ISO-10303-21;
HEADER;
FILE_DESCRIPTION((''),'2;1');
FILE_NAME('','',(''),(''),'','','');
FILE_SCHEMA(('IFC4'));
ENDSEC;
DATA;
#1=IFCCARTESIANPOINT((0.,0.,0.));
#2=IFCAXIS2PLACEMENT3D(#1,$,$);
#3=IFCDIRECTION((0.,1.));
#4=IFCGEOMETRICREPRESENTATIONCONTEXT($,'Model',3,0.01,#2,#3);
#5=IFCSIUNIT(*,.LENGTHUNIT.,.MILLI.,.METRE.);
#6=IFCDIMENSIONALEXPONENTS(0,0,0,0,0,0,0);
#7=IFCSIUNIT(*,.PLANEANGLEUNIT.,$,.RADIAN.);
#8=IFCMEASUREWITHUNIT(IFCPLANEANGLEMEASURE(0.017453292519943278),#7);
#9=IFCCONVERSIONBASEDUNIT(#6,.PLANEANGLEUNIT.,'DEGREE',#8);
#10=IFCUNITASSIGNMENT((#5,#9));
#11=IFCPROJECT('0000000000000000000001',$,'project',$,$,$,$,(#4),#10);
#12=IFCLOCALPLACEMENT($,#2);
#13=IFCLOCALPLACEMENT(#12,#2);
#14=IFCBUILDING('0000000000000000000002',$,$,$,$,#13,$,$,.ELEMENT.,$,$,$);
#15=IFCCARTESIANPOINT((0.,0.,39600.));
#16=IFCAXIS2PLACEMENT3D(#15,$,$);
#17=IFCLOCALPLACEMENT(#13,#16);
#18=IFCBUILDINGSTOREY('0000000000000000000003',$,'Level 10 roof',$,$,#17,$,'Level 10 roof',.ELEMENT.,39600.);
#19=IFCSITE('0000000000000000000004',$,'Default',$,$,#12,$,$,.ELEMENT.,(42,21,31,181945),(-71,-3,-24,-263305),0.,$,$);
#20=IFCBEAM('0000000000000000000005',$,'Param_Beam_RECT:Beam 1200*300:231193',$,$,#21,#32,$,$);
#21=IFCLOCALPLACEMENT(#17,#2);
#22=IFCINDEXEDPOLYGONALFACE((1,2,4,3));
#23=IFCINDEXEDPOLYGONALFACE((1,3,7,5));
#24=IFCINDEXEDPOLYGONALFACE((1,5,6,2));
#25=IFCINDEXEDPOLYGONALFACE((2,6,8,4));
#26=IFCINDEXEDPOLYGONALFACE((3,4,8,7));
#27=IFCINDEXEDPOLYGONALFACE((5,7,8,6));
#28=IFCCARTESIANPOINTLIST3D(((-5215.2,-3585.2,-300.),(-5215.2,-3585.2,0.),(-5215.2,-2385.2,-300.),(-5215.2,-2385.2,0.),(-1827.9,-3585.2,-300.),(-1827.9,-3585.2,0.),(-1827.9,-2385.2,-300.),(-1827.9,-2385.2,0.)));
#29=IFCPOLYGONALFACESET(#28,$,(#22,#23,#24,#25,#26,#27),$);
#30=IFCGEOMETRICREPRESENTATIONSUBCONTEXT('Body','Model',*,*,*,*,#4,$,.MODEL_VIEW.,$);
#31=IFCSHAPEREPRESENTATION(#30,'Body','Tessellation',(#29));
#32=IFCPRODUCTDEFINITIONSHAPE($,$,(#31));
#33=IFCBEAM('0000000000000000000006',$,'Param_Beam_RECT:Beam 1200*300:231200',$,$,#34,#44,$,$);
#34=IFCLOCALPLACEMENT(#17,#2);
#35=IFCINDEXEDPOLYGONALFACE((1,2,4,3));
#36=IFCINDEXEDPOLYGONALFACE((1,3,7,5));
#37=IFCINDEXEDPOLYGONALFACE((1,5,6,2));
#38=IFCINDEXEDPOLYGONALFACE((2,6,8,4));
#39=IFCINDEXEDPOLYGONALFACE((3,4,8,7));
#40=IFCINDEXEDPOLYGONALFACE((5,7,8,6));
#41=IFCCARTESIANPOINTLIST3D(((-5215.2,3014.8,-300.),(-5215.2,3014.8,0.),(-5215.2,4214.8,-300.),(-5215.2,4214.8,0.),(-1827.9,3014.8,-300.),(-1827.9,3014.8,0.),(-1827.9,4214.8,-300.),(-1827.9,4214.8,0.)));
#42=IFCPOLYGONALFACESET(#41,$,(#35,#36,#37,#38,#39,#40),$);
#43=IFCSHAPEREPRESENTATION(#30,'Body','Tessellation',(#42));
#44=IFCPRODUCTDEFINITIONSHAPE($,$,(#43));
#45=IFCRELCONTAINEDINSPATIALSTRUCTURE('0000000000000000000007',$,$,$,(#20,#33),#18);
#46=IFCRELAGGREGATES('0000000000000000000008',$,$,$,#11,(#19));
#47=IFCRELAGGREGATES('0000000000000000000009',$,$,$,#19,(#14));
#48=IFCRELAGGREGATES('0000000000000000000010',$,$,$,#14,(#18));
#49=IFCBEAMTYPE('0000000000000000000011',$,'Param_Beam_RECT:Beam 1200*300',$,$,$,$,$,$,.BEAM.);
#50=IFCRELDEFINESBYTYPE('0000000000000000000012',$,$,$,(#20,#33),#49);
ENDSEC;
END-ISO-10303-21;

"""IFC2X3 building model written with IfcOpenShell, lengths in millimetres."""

from ifc_helpers import new_model, entity, si_unit, converted_unit, direction, frame, frame_2d, origin, place, context, subcontext, project, spatial, rectangle, extrude, type_object, element, save


model = new_model("IFC2X3")

# Units and contexts
model_context = context("Model", 3, precision=0.01, world=origin(), true_north=direction((0.0, 1.0)))
body_context = subcontext(model_context, "Body", "Model", "MODEL_VIEW")
ifc_project = project(units=[si_unit("LENGTHUNIT", "METRE", prefix="MILLI"), converted_unit("PLANEANGLEUNIT", "DEGREE", entity("IfcPlaneAngleMeasure", 0.017453292519943278), si_unit("PLANEANGLEUNIT", "RADIAN"), dimensions=[0, 0, 0, 0, 0, 0, 0])], contexts=[model_context])

# Site, building, storey
site_placement = place(None, origin())
site = spatial("IfcSite", under=ifc_project, at=site_placement, Name="Default", CompositionType="ELEMENT", RefLatitude=(42, 21, 31, 181945), RefLongitude=(-71, -3, -24, -263305), RefElevation=0.0)
building_placement = place(site_placement, origin())
building = spatial("IfcBuilding", under=site, at=building_placement, CompositionType="ELEMENT")
storey_placement = place(building_placement, frame((0.0, 0.0, 39600.0)))
storey = spatial("IfcBuildingStorey", under=building, at=storey_placement, Name="Level 10 roof", LongName="Level 10 roof", CompositionType="ELEMENT", Elevation=39600.0)

# Beams
beam_type_1 = type_object("IfcBeamType", Name="Param_Beam_RECT:Beam 1200*300", PredefinedType="BEAM")
beam_1_placement = place(storey_placement, frame((-5215.2, -2985.2, 0.0)))
element("IfcBeam", 1, at=beam_1_placement, inside=storey, type_object=beam_type_1, Name="Param_Beam_RECT:Beam 1200*300:231193", context=body_context, shape_type="SweptSolid", body=[
    extrude(rectangle(XDim=300.0, YDim=1200.0, at=frame_2d((0.0, 0.0), x_axis=(1.0, 0.0))), frame((0.0, 0.0, -150.0), z_axis=(1.0, 0.0, 0.0), x_axis=(0.0, 0.0, -1.0)), (0.0, 0.0, 1.0), 3387.3),
])
beam_2_placement = place(storey_placement, frame((-5215.2, 3614.8, 0.0)))
element("IfcBeam", 2, at=beam_2_placement, inside=storey, type_object=beam_type_1, Name="Param_Beam_RECT:Beam 1200*300:231200", context=body_context, shape_type="SweptSolid", body=[
    extrude(rectangle(XDim=300.0, YDim=1200.0, at=frame_2d((0.0, 0.0), x_axis=(1.0, 0.0))), frame((0.0, 0.0, -150.0), z_axis=(1.0, 0.0, 0.0), x_axis=(0.0, 0.0, -1.0)), (0.0, 0.0, 1.0), 3387.3),
])

save(model, "model.ifc")
